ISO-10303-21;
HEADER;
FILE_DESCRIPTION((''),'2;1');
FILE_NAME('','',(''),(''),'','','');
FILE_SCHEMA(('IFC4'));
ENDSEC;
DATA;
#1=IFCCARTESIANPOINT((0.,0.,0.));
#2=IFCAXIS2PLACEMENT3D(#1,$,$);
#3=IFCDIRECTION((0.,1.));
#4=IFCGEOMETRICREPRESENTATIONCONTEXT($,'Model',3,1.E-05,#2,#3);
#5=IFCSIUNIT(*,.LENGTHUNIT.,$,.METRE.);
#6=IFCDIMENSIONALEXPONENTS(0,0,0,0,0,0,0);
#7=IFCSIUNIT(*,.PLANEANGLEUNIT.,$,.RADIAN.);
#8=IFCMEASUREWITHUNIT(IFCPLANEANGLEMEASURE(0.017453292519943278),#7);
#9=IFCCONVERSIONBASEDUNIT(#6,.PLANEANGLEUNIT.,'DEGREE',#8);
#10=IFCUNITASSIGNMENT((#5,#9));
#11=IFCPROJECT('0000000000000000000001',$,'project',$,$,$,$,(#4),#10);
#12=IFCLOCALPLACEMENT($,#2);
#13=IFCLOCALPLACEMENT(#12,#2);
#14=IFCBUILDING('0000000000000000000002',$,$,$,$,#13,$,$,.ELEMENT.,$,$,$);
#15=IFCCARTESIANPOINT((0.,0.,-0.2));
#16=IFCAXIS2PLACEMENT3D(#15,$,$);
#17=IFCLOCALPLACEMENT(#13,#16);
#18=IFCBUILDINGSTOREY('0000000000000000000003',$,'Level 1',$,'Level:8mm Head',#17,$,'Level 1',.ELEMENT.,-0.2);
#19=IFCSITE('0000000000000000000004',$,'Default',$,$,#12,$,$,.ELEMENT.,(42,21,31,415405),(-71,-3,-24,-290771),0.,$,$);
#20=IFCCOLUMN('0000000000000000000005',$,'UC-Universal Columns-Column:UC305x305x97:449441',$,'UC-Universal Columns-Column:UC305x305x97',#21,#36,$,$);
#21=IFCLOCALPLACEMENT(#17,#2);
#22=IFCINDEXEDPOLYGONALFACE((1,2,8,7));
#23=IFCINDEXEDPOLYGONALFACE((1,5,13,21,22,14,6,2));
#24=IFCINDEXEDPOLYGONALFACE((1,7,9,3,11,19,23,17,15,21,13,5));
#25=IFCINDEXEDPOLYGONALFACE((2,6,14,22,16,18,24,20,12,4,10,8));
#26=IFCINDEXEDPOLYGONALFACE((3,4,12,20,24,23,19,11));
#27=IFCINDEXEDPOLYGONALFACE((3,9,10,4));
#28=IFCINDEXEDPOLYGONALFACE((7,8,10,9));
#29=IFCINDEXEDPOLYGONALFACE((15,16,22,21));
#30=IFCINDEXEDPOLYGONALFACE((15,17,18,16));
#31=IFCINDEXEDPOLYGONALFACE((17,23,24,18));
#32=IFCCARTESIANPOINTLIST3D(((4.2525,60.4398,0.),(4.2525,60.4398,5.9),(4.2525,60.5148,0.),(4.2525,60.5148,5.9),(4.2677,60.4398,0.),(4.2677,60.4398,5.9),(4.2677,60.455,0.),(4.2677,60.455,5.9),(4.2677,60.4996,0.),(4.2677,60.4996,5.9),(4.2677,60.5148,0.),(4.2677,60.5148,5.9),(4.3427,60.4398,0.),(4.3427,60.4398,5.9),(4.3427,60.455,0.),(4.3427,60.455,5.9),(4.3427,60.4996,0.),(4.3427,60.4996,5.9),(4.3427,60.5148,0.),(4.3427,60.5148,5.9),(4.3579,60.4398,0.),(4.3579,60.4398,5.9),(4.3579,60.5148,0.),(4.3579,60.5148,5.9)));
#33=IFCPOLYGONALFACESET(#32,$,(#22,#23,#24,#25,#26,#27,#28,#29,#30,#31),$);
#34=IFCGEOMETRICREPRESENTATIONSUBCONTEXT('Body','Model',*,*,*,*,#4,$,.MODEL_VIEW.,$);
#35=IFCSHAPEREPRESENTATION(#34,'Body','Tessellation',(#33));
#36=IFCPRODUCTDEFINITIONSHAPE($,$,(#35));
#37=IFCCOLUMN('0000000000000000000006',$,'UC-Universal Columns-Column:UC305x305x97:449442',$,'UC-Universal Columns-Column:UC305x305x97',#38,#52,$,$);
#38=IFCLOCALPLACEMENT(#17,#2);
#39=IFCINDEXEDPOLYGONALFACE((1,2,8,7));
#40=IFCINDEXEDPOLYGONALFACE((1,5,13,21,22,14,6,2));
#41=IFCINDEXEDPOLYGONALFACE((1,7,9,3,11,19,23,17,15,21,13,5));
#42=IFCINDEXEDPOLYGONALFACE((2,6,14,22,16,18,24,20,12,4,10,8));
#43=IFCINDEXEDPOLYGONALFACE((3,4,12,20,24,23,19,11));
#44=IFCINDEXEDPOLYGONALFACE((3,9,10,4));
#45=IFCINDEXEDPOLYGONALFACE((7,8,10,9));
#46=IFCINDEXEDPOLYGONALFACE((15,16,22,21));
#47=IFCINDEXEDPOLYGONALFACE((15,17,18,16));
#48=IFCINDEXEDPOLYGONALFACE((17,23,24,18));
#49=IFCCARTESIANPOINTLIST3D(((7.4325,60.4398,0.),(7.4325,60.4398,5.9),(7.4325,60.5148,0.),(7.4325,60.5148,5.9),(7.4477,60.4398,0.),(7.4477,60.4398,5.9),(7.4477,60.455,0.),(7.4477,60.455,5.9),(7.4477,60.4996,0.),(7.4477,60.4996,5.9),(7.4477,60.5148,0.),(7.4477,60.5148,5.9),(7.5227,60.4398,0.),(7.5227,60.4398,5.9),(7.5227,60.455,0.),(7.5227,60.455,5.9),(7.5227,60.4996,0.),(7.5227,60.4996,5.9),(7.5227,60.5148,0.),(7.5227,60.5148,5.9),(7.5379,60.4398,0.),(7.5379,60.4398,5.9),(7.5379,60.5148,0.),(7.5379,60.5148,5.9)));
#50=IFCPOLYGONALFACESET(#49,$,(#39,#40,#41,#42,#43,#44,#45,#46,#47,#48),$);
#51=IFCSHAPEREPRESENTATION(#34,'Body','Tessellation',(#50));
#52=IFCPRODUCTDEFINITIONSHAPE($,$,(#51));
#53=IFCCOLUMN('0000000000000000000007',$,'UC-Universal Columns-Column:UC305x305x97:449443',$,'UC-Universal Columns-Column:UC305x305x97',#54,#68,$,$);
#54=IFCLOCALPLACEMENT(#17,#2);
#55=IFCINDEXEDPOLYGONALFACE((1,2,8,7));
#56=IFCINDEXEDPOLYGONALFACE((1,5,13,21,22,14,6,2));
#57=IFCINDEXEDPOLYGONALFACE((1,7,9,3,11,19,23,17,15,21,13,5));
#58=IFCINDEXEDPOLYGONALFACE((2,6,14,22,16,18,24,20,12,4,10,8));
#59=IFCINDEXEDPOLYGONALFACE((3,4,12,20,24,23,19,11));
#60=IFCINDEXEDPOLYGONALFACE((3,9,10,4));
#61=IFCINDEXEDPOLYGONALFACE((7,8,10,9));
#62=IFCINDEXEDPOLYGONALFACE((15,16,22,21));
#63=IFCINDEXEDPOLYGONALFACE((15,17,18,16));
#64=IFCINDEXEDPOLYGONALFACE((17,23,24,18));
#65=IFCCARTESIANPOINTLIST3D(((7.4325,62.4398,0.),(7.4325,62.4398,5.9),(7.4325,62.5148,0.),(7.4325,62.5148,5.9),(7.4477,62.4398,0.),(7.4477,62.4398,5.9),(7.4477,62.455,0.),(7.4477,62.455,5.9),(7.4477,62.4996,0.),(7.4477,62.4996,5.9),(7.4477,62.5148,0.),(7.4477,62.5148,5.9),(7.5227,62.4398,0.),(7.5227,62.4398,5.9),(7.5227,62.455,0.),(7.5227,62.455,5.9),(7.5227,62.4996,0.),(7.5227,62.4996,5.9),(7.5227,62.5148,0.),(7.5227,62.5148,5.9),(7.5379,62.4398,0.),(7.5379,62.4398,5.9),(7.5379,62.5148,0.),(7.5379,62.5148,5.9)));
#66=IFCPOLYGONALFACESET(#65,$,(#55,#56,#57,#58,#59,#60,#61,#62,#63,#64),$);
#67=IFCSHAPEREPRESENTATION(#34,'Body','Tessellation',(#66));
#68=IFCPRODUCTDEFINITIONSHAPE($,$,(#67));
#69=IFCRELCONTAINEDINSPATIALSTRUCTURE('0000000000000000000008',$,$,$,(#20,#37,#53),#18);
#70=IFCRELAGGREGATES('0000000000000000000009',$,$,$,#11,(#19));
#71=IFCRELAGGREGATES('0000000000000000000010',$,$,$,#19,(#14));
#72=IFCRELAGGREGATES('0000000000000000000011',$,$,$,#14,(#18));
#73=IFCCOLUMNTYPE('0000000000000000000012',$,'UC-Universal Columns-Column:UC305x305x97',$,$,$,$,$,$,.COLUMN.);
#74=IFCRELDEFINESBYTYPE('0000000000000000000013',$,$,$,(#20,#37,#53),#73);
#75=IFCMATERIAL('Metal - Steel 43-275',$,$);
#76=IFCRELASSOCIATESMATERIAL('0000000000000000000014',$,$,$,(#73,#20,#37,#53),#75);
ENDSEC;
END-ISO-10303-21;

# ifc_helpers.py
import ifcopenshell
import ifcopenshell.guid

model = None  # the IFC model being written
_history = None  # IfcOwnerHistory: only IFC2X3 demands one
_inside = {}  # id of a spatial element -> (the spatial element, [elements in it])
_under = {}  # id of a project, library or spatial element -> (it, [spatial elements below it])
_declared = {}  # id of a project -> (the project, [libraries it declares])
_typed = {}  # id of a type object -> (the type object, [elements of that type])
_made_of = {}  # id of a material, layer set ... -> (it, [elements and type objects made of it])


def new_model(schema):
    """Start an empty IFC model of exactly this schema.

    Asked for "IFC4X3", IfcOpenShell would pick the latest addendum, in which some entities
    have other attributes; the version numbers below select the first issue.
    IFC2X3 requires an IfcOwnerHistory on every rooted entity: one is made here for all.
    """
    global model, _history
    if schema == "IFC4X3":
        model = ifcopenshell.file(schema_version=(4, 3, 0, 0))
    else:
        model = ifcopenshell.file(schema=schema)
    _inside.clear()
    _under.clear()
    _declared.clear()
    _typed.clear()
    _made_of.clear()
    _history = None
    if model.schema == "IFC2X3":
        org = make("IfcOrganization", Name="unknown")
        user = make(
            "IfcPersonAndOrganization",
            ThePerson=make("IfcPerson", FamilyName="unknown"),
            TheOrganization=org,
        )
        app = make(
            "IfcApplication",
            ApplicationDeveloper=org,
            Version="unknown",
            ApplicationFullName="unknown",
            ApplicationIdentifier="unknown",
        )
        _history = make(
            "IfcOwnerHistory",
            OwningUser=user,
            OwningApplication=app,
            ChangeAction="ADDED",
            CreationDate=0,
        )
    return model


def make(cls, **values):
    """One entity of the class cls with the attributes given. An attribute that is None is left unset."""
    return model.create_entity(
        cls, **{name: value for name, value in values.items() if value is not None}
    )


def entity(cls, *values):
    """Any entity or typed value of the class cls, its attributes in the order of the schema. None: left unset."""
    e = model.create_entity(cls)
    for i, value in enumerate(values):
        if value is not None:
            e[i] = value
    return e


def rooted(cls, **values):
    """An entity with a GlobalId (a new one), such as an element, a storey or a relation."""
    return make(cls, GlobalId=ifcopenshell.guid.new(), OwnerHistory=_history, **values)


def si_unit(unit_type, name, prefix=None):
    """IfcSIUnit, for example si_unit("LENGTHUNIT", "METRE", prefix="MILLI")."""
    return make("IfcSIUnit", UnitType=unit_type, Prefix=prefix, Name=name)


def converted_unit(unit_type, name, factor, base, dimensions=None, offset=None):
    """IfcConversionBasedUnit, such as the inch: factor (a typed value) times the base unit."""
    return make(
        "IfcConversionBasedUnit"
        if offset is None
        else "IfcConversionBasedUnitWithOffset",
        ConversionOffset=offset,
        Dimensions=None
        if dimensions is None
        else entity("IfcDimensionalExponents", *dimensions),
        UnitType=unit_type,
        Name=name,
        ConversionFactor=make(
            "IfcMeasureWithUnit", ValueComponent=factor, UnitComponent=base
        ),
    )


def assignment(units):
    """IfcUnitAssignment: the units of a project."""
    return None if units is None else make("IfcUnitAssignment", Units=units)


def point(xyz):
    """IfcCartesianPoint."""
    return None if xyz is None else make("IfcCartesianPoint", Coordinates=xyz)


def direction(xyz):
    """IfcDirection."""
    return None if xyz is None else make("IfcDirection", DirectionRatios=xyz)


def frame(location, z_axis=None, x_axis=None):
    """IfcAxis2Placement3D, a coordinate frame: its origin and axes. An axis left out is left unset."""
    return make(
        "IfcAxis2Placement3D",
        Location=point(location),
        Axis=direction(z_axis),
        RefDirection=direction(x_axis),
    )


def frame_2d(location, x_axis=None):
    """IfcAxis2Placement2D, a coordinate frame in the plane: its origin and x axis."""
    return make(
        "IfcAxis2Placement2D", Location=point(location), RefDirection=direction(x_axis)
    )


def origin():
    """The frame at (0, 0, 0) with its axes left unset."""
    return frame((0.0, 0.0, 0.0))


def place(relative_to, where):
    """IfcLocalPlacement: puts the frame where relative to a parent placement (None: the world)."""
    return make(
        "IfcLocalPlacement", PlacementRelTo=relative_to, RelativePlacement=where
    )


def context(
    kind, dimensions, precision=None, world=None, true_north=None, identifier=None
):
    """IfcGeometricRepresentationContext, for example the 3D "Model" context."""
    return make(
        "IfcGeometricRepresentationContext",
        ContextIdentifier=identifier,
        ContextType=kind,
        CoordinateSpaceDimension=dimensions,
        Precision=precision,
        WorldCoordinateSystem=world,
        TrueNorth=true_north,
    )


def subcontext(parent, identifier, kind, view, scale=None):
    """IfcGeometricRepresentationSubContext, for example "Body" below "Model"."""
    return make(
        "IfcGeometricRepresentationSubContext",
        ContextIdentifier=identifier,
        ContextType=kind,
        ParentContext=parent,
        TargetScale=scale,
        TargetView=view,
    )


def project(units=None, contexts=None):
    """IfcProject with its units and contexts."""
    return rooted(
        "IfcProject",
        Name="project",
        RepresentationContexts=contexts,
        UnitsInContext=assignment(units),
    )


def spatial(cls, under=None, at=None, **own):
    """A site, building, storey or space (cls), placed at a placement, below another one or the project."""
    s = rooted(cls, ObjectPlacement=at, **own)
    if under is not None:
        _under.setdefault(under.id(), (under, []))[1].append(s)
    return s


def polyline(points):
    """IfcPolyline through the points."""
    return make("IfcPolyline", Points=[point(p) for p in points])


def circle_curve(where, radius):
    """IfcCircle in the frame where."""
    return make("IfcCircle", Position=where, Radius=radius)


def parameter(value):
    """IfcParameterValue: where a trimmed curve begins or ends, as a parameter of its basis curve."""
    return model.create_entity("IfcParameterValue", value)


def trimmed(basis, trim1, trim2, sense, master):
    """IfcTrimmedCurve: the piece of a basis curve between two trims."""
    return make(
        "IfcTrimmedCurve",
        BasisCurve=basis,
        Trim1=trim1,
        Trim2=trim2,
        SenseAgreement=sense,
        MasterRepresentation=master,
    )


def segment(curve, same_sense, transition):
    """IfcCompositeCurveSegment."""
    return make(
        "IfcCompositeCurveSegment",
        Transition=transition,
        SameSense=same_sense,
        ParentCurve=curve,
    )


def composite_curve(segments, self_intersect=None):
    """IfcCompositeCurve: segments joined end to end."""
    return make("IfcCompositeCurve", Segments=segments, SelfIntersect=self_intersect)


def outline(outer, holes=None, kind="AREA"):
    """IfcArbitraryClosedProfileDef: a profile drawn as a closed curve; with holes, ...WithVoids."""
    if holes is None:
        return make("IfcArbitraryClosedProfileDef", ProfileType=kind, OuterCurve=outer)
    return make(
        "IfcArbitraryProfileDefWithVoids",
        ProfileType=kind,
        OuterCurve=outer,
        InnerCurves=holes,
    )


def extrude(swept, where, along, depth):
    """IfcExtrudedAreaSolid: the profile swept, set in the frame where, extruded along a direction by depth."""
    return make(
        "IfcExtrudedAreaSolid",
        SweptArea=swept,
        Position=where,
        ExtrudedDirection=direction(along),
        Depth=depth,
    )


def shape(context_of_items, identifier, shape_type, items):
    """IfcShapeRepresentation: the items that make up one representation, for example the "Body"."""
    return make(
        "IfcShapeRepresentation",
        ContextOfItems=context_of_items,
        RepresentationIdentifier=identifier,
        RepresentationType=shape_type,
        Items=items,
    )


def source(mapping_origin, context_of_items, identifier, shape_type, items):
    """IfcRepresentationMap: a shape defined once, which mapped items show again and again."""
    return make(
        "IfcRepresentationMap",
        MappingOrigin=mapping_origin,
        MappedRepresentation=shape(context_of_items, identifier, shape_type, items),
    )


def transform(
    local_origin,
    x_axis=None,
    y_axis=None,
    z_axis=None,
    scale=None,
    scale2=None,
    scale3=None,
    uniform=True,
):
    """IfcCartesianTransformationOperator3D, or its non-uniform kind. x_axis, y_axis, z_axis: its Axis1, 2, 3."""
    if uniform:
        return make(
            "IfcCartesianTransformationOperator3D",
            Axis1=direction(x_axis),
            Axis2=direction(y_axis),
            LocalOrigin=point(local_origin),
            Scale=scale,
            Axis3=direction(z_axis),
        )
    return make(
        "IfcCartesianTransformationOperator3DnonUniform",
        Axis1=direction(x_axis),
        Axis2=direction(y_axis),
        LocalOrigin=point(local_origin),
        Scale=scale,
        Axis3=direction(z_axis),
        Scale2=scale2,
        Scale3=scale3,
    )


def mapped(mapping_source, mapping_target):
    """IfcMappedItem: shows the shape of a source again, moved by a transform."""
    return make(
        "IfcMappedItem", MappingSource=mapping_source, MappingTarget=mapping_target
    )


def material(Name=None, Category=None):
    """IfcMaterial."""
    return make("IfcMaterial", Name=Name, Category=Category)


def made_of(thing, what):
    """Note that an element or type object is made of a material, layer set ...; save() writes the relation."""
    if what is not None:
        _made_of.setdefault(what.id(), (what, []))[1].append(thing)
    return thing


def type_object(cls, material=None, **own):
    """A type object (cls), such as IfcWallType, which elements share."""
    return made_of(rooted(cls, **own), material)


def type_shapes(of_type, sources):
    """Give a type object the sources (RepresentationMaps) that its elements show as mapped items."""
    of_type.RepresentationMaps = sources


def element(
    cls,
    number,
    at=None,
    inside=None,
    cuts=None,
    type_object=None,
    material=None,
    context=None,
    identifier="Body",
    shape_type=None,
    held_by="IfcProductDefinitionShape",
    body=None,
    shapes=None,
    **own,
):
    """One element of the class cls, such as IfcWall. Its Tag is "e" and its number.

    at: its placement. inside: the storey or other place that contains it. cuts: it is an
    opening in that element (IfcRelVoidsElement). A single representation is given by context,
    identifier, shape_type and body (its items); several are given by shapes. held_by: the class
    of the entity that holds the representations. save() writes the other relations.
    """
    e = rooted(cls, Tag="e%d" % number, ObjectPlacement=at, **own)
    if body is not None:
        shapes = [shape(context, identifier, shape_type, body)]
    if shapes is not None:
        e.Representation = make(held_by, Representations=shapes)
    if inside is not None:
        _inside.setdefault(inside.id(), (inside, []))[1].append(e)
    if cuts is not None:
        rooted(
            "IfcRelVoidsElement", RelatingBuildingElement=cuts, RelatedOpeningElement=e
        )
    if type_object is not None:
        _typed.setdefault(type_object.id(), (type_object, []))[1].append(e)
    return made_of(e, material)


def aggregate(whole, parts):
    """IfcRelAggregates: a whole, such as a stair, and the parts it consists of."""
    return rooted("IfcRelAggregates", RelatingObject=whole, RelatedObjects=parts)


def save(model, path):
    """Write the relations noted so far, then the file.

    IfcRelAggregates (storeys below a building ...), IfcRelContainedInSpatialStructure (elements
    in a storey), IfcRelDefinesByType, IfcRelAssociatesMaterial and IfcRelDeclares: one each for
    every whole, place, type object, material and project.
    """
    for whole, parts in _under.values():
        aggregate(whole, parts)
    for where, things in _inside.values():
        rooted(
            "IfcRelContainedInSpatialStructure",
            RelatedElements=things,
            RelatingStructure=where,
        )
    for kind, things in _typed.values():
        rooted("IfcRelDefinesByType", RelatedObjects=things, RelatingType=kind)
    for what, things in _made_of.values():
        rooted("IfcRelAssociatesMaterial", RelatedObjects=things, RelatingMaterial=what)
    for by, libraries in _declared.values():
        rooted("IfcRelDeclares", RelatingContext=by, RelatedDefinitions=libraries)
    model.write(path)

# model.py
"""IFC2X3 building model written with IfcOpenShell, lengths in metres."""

from ifc_helpers import new_model, entity, si_unit, converted_unit, direction, frame, frame_2d, origin, place, context, subcontext, project, spatial, polyline, circle_curve, parameter, trimmed, segment, composite_curve, outline, extrude, source, transform, mapped, material, type_object, type_shapes, element, save


model = new_model("IFC2X3")

# Units and contexts
model_context = context("Model", 3, precision=1e-05, world=origin(), true_north=direction((0.0, 1.0)))
body_context = subcontext(model_context, "Body", "Model", "MODEL_VIEW")
ifc_project = project(units=[si_unit("LENGTHUNIT", "METRE"), converted_unit("PLANEANGLEUNIT", "DEGREE", entity("IfcPlaneAngleMeasure", 0.017453292519943278), si_unit("PLANEANGLEUNIT", "RADIAN"), dimensions=[0, 0, 0, 0, 0, 0, 0])], contexts=[model_context])

# Site, building, storey
site_placement = place(None, origin())
site = spatial("IfcSite", under=ifc_project, at=site_placement, Name="Default", CompositionType="ELEMENT", RefLatitude=(42, 21, 31, 415405), RefLongitude=(-71, -3, -24, -290771), RefElevation=0.0)
building_placement = place(site_placement, origin())
building = spatial("IfcBuilding", under=site, at=building_placement, CompositionType="ELEMENT")
storey_placement = place(building_placement, frame((0.0, 0.0, -0.2)))
storey = spatial("IfcBuildingStorey", under=building, at=storey_placement, Name="Level 1", ObjectType="Level:8mm Head", LongName="Level 1", CompositionType="ELEMENT", Elevation=-0.2)

# Columns
ifc_material = material(Name="Metal - Steel 43-275")
column_type = type_object("IfcColumnType", Name="UC-Universal Columns-Column:UC305x305x97", PredefinedType="COLUMN", material=ifc_material)
shared_shape = source(origin(), body_context, "Body", "SweptSolid", [
    extrude(outline(composite_curve([segment(polyline([(-0.0375, -0.0375), (0.0375, -0.0375)]), True, "CONTINUOUS"), segment(polyline([(0.0375, -0.0375), (0.0527, -0.0375)]), True, "CONTINUOUS"), segment(trimmed(circle_curve(frame_2d((0.0527, -0.0223), x_axis=(-1.0, 0.0)), 0.0152), [parameter(0.0)], [parameter(90.0)], True, "PARAMETER"), False, "CONTINUOUS"), segment(polyline([(0.0375, -0.0223), (0.0375, 0.0223)]), True, "CONTINUOUS"), segment(trimmed(circle_curve(frame_2d((0.0527, 0.0223), x_axis=(-1.0, 0.0)), 0.0152), [parameter(270.0)], [parameter(0.0)], True, "PARAMETER"), False, "CONTINUOUS"), segment(polyline([(0.0527, 0.0375), (0.0375, 0.0375)]), True, "CONTINUOUS"), segment(polyline([(0.0375, 0.0375), (-0.0375, 0.0375)]), True, "CONTINUOUS"), segment(polyline([(-0.0375, 0.0375), (-0.0527, 0.0375)]), True, "CONTINUOUS"), segment(trimmed(circle_curve(frame_2d((-0.0527, 0.0223), x_axis=(-1.0, 0.0)), 0.0152), [parameter(180.0)], [parameter(270.0)], True, "PARAMETER"), False, "CONTINUOUS"), segment(polyline([(-0.0375, 0.0223), (-0.0375, -0.0223)]), True, "CONTINUOUS"), segment(trimmed(circle_curve(frame_2d((-0.0527, -0.0223), x_axis=(-1.0, 0.0)), 0.0152), [parameter(90.0)], [parameter(180.0)], True, "PARAMETER"), False, "CONTINUOUS"), segment(polyline([(-0.0527, -0.0375), (-0.0375, -0.0375)]), True, "CONTINUOUS")], self_intersect=False)), frame((0.0, 0.0, -0.2), z_axis=(0.0, 0.0, 1.0), x_axis=(-1.0, 0.0, 0.0)), (0.0, 0.0, 1.0), 5.9),
])
type_shapes(column_type, [shared_shape])
for number, where, z_axis, x_axis, name in (
    (1, (4.3052, 60.4773, 0.2), (0.0, 0.0, 1.0), (-1.0, 0.0, 0.0), "UC-Universal Columns-Column:UC305x305x97:449441"),
    (2, (7.4852, 60.4773, 0.2), (0.0, 0.0, 1.0), (-1.0, 0.0, 0.0), "UC-Universal Columns-Column:UC305x305x97:449442"),
    (3, (7.4852, 62.4773, 0.2), (0.0, 0.0, 1.0), (-1.0, 0.0, 0.0), "UC-Universal Columns-Column:UC305x305x97:449443"),
):
    element("IfcColumn", number, at=place(storey_placement, frame(where, z_axis=z_axis, x_axis=x_axis)), inside=storey, type_object=column_type, material=ifc_material, Name=name, ObjectType="UC-Universal Columns-Column:UC305x305x97", context=body_context, shape_type="MappedRepresentation", body=[
        mapped(shared_shape, transform((0.0, 0.0, 0.0), scale=1.0)),
    ])

save(model, "model.ifc")
